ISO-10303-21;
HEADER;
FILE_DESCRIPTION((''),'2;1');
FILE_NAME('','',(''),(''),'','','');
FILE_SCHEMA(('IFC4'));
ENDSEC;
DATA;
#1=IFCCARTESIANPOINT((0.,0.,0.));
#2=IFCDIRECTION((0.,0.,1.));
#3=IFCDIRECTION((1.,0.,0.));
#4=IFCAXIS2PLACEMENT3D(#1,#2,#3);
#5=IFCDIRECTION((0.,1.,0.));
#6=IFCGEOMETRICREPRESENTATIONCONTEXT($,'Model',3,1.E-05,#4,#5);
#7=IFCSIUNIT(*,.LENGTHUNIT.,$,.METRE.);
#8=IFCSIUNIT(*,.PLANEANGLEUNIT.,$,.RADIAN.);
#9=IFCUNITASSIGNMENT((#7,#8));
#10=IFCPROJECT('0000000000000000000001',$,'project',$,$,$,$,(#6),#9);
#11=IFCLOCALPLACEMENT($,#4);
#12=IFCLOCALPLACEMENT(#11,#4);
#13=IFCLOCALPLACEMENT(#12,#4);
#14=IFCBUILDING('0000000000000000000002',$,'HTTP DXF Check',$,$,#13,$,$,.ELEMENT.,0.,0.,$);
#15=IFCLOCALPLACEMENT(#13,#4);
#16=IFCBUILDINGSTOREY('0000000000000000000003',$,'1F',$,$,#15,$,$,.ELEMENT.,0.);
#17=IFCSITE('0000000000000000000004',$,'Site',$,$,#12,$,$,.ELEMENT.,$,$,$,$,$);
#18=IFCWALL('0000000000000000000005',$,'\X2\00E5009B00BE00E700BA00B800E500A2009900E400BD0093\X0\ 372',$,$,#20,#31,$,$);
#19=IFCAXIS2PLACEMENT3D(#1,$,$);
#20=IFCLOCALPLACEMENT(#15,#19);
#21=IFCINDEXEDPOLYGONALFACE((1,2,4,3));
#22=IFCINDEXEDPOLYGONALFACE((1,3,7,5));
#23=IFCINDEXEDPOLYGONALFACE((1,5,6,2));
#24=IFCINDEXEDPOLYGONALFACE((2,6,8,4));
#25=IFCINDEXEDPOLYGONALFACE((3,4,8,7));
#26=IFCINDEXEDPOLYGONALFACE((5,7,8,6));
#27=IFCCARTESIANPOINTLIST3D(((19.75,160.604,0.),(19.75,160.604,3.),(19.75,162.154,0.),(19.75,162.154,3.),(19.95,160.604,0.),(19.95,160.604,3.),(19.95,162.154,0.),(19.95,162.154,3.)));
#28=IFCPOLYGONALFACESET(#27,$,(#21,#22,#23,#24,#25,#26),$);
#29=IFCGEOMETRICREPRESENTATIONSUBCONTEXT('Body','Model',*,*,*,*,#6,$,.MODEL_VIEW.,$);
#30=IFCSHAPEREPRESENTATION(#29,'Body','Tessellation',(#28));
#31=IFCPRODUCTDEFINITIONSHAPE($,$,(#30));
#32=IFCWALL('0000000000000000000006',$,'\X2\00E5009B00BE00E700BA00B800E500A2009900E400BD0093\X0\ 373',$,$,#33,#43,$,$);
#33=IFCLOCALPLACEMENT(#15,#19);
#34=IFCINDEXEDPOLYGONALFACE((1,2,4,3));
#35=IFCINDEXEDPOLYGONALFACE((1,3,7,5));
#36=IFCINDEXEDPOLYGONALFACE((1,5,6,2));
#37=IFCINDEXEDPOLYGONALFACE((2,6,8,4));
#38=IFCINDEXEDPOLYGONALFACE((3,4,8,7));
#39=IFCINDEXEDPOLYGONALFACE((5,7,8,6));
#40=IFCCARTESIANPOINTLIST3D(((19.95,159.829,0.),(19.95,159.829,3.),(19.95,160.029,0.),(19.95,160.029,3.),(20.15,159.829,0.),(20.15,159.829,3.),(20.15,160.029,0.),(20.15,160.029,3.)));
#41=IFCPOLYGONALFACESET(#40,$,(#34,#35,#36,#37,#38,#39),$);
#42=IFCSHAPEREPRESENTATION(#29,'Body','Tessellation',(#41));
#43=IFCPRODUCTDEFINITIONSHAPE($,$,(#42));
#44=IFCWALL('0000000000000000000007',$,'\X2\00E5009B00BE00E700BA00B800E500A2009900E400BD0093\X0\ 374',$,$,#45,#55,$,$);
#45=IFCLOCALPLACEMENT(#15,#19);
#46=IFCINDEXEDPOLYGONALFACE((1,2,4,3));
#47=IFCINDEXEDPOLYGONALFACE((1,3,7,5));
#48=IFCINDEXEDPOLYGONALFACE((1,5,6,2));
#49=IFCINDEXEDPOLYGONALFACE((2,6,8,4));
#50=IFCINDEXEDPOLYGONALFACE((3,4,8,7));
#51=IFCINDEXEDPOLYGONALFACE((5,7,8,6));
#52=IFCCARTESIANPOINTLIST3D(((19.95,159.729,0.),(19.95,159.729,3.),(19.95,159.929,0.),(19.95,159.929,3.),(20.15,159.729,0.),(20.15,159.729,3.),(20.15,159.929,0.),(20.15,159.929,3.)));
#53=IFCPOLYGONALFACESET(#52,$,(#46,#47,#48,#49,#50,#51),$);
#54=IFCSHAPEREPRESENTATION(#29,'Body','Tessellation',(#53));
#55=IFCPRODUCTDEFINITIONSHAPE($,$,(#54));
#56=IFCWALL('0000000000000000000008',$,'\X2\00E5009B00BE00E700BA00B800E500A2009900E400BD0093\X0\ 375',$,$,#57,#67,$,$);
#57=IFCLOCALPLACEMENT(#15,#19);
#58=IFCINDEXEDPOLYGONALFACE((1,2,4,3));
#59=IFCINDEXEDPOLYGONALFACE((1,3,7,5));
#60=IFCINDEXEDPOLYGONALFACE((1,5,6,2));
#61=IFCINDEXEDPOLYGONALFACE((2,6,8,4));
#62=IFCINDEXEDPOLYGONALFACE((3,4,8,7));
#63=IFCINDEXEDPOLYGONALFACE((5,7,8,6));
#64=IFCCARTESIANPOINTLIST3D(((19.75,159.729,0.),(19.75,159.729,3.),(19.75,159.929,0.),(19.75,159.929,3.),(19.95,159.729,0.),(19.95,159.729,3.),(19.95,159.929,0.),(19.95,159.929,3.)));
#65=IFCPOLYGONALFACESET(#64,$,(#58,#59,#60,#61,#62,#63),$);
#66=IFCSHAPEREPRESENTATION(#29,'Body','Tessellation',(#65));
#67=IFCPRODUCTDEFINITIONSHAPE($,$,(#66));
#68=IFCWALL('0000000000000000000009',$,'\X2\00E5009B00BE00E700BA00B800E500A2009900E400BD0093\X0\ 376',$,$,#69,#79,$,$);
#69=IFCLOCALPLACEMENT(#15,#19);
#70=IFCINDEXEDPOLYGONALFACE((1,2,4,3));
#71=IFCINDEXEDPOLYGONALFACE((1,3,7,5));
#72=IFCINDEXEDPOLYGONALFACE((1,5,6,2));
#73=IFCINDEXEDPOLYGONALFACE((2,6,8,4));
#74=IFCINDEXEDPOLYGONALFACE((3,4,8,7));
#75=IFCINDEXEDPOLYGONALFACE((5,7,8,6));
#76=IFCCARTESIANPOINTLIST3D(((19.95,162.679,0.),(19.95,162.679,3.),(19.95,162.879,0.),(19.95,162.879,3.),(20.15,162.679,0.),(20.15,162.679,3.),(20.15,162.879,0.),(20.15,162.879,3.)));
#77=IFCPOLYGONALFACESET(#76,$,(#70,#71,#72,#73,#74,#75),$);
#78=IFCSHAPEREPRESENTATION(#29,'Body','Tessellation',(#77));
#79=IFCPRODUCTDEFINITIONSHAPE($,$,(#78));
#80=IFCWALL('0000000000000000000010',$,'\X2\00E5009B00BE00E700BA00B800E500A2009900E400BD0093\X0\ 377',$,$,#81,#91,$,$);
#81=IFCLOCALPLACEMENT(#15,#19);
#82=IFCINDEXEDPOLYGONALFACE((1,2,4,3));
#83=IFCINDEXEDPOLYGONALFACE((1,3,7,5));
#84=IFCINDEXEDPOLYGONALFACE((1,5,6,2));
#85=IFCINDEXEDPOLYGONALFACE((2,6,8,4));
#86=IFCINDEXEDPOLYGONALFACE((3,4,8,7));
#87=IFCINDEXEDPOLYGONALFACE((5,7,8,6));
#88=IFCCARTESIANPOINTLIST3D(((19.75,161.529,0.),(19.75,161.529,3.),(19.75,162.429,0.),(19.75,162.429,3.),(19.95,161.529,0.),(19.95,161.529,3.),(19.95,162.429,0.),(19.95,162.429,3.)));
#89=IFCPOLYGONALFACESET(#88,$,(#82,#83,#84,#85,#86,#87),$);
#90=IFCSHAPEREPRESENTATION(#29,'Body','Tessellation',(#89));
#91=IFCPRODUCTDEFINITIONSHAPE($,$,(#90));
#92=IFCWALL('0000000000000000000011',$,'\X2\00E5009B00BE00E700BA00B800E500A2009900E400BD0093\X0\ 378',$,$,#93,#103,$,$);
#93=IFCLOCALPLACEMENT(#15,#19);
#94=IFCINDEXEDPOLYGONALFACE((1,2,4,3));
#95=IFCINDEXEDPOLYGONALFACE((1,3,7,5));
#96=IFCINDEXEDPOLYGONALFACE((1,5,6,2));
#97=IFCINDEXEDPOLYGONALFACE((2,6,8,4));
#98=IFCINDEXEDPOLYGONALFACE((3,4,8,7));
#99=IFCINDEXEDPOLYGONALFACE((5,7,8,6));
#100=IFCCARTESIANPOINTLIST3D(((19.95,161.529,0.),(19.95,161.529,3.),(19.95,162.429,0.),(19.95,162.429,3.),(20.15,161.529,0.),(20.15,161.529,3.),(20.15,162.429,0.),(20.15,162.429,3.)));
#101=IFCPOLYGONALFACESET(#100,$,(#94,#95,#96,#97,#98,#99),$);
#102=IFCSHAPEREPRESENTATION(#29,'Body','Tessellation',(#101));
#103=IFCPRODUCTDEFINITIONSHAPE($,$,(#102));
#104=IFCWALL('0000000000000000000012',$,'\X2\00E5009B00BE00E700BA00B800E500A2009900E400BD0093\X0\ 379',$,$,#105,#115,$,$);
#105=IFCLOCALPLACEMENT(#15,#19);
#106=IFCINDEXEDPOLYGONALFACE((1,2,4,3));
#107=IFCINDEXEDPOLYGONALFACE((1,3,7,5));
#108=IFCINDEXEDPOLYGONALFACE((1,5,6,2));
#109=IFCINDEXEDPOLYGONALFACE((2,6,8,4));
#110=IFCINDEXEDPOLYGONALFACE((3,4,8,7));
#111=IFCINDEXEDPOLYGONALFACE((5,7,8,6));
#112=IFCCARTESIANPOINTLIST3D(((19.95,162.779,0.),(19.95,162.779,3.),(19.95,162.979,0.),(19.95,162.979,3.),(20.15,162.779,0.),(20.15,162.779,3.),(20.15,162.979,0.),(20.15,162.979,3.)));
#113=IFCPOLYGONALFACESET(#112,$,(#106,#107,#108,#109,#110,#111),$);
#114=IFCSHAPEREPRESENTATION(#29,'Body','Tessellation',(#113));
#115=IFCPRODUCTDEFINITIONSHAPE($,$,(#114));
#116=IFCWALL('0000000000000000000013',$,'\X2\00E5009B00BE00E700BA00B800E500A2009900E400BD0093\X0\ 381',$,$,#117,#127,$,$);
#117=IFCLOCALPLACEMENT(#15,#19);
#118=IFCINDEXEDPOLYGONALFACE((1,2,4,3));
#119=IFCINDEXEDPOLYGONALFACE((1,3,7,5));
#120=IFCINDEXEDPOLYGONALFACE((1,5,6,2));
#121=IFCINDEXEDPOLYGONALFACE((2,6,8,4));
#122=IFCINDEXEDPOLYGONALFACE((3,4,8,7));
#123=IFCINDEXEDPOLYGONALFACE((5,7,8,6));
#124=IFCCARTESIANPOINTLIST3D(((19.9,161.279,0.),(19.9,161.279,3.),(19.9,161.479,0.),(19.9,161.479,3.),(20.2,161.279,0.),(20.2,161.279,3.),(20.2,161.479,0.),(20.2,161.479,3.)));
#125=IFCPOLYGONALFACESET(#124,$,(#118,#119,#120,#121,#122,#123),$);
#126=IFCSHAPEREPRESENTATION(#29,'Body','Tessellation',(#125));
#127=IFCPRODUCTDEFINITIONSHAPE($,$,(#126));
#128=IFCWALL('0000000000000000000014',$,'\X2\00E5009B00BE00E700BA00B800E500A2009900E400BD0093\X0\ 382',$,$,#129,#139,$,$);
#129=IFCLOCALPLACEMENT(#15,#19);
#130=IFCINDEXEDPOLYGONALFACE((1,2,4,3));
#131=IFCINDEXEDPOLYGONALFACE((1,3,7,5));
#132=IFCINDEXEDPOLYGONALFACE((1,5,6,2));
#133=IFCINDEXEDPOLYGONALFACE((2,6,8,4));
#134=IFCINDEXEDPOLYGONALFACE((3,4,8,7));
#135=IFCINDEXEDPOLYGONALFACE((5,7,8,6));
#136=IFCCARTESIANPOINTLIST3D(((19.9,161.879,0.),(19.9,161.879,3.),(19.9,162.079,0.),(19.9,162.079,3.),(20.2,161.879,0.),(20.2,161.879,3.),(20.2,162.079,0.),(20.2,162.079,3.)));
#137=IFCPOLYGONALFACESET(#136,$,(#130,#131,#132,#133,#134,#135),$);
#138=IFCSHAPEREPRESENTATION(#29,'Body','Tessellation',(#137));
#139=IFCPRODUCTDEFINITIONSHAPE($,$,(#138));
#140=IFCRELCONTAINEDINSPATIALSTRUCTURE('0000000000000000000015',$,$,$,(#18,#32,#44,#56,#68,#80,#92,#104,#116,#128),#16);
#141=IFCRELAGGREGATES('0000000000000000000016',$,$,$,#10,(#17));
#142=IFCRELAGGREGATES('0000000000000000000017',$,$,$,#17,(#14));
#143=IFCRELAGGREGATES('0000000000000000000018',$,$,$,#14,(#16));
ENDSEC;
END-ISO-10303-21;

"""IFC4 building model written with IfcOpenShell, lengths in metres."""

from ifc_helpers import new_model, si_unit, direction, frame, frame_2d, origin_with_axes, place, context, subcontext, project, spatial, rectangle, extrude, element, save


model = new_model("IFC4")

# Units and contexts
model_context = context("Model", 3, precision=1e-05, world=origin_with_axes(), true_north=direction((0.0, 1.0, 0.0)))
body_context = subcontext(model_context, "Body", "Model", "MODEL_VIEW")
ifc_project = project(units=[si_unit("LENGTHUNIT", "METRE"), si_unit("PLANEANGLEUNIT", "RADIAN")], contexts=[model_context])

# Site, building, storey
placement = place(None, origin_with_axes())
site_placement = place(placement, origin_with_axes())
site = spatial("IfcSite", under=ifc_project, at=site_placement, Name="Site", CompositionType="ELEMENT")
building_placement = place(site_placement, origin_with_axes())
building = spatial("IfcBuilding", under=site, at=building_placement, Name="HTTP DXF Check", CompositionType="ELEMENT", ElevationOfRefHeight=0.0, ElevationOfTerrain=0.0)
storey_placement = place(building_placement, origin_with_axes())
storey = spatial("IfcBuildingStorey", under=building, at=storey_placement, Name="1F", CompositionType="ELEMENT", Elevation=0.0)

# Walls
wall_1_placement = place(storey_placement, frame((19.85, 161.379, 0.0), z_axis=(0.0, 0.0, 1.0), x_axis=(0.0, -1.0, 0.0)))
element("IfcWall", 1, at=wall_1_placement, inside=storey, Name="å\u009b¾çº¸å¢\u0099ä½\u0093 372", context=body_context, shape_type="SweptSolid", body=[
    extrude(rectangle(XDim=1.55, YDim=0.2, at=frame_2d((0.0, 0.0), x_axis=(1.0, 0.0, 0.0))), frame((0.0, 0.0, 0.0), z_axis=(0.0, 0.0, 1.0)), (0.0, 0.0, 1.0), 3.0),
])
for number, where, z_axis, x_axis, name in (
    (2, (20.05, 159.929, 0.0), (0.0, 0.0, 1.0), (-1.0, 0.0, 0.0), "å\u009b¾çº¸å¢\u0099ä½\u0093 373"),
    (3, (20.05, 159.829, 0.0), (0.0, 0.0, 1.0), (-1.0, 0.0, 0.0), "å\u009b¾çº¸å¢\u0099ä½\u0093 374"),
    (4, (19.85, 159.829, 0.0), (0.0, 0.0, 1.0), (1.0, 0.0, 0.0), "å\u009b¾çº¸å¢\u0099ä½\u0093 375"),
    (5, (20.05, 162.779, 0.0), (0.0, 0.0, 1.0), (-1.0, 0.0, 0.0), "å\u009b¾çº¸å¢\u0099ä½\u0093 376"),
):
    element("IfcWall", number, at=place(storey_placement, frame(where, z_axis=z_axis, x_axis=x_axis)), inside=storey, Name=name, context=body_context, shape_type="SweptSolid", body=[
        extrude(rectangle(XDim=0.2, YDim=0.2, at=frame_2d((0.0, 0.0), x_axis=(1.0, 0.0, 0.0))), frame((0.0, 0.0, 0.0), z_axis=(0.0, 0.0, 1.0)), (0.0, 0.0, 1.0), 3.0),
    ])
for number, where, z_axis, x_axis, name in (
    (6, (19.85, 161.979, 0.0), (0.0, 0.0, 1.0), (0.0, 1.0, 0.0), "å\u009b¾çº¸å¢\u0099ä½\u0093 377"),
    (7, (20.05, 161.979, 0.0), (0.0, 0.0, 1.0), (0.0, 1.0, 0.0), "å\u009b¾çº¸å¢\u0099ä½\u0093 378"),
):
    element("IfcWall", number, at=place(storey_placement, frame(where, z_axis=z_axis, x_axis=x_axis)), inside=storey, Name=name, context=body_context, shape_type="SweptSolid", body=[
        extrude(rectangle(XDim=0.9, YDim=0.2, at=frame_2d((0.0, 0.0), x_axis=(1.0, 0.0, 0.0))), frame((0.0, 0.0, 0.0), z_axis=(0.0, 0.0, 1.0)), (0.0, 0.0, 1.0), 3.0),
    ])
wall_2_placement = place(storey_placement, frame((20.05, 162.879, 0.0), z_axis=(0.0, 0.0, 1.0), x_axis=(-1.0, 0.0, 0.0)))
element("IfcWall", 8, at=wall_2_placement, inside=storey, Name="å\u009b¾çº¸å¢\u0099ä½\u0093 379", context=body_context, shape_type="SweptSolid", body=[
    extrude(rectangle(XDim=0.2, YDim=0.2, at=frame_2d((0.0, 0.0), x_axis=(1.0, 0.0, 0.0))), frame((0.0, 0.0, 0.0), z_axis=(0.0, 0.0, 1.0)), (0.0, 0.0, 1.0), 3.0),
])
for number, where, z_axis, x_axis, name in (
    (9, (20.05, 161.379, 0.0), (0.0, 0.0, 1.0), (-1.0, 0.0, 0.0), "å\u009b¾çº¸å¢\u0099ä½\u0093 381"),
    (10, (20.05, 161.979, 0.0), (0.0, 0.0, 1.0), (-1.0, 0.0, 0.0), "å\u009b¾çº¸å¢\u0099ä½\u0093 382"),
):
    element("IfcWall", number, at=place(storey_placement, frame(where, z_axis=z_axis, x_axis=x_axis)), inside=storey, Name=name, context=body_context, shape_type="SweptSolid", body=[
        extrude(rectangle(XDim=0.3, YDim=0.2, at=frame_2d((0.0, 0.0), x_axis=(1.0, 0.0, 0.0))), frame((0.0, 0.0, 0.0), z_axis=(0.0, 0.0, 1.0)), (0.0, 0.0, 1.0), 3.0),
    ])

save(model, "model.ifc")
